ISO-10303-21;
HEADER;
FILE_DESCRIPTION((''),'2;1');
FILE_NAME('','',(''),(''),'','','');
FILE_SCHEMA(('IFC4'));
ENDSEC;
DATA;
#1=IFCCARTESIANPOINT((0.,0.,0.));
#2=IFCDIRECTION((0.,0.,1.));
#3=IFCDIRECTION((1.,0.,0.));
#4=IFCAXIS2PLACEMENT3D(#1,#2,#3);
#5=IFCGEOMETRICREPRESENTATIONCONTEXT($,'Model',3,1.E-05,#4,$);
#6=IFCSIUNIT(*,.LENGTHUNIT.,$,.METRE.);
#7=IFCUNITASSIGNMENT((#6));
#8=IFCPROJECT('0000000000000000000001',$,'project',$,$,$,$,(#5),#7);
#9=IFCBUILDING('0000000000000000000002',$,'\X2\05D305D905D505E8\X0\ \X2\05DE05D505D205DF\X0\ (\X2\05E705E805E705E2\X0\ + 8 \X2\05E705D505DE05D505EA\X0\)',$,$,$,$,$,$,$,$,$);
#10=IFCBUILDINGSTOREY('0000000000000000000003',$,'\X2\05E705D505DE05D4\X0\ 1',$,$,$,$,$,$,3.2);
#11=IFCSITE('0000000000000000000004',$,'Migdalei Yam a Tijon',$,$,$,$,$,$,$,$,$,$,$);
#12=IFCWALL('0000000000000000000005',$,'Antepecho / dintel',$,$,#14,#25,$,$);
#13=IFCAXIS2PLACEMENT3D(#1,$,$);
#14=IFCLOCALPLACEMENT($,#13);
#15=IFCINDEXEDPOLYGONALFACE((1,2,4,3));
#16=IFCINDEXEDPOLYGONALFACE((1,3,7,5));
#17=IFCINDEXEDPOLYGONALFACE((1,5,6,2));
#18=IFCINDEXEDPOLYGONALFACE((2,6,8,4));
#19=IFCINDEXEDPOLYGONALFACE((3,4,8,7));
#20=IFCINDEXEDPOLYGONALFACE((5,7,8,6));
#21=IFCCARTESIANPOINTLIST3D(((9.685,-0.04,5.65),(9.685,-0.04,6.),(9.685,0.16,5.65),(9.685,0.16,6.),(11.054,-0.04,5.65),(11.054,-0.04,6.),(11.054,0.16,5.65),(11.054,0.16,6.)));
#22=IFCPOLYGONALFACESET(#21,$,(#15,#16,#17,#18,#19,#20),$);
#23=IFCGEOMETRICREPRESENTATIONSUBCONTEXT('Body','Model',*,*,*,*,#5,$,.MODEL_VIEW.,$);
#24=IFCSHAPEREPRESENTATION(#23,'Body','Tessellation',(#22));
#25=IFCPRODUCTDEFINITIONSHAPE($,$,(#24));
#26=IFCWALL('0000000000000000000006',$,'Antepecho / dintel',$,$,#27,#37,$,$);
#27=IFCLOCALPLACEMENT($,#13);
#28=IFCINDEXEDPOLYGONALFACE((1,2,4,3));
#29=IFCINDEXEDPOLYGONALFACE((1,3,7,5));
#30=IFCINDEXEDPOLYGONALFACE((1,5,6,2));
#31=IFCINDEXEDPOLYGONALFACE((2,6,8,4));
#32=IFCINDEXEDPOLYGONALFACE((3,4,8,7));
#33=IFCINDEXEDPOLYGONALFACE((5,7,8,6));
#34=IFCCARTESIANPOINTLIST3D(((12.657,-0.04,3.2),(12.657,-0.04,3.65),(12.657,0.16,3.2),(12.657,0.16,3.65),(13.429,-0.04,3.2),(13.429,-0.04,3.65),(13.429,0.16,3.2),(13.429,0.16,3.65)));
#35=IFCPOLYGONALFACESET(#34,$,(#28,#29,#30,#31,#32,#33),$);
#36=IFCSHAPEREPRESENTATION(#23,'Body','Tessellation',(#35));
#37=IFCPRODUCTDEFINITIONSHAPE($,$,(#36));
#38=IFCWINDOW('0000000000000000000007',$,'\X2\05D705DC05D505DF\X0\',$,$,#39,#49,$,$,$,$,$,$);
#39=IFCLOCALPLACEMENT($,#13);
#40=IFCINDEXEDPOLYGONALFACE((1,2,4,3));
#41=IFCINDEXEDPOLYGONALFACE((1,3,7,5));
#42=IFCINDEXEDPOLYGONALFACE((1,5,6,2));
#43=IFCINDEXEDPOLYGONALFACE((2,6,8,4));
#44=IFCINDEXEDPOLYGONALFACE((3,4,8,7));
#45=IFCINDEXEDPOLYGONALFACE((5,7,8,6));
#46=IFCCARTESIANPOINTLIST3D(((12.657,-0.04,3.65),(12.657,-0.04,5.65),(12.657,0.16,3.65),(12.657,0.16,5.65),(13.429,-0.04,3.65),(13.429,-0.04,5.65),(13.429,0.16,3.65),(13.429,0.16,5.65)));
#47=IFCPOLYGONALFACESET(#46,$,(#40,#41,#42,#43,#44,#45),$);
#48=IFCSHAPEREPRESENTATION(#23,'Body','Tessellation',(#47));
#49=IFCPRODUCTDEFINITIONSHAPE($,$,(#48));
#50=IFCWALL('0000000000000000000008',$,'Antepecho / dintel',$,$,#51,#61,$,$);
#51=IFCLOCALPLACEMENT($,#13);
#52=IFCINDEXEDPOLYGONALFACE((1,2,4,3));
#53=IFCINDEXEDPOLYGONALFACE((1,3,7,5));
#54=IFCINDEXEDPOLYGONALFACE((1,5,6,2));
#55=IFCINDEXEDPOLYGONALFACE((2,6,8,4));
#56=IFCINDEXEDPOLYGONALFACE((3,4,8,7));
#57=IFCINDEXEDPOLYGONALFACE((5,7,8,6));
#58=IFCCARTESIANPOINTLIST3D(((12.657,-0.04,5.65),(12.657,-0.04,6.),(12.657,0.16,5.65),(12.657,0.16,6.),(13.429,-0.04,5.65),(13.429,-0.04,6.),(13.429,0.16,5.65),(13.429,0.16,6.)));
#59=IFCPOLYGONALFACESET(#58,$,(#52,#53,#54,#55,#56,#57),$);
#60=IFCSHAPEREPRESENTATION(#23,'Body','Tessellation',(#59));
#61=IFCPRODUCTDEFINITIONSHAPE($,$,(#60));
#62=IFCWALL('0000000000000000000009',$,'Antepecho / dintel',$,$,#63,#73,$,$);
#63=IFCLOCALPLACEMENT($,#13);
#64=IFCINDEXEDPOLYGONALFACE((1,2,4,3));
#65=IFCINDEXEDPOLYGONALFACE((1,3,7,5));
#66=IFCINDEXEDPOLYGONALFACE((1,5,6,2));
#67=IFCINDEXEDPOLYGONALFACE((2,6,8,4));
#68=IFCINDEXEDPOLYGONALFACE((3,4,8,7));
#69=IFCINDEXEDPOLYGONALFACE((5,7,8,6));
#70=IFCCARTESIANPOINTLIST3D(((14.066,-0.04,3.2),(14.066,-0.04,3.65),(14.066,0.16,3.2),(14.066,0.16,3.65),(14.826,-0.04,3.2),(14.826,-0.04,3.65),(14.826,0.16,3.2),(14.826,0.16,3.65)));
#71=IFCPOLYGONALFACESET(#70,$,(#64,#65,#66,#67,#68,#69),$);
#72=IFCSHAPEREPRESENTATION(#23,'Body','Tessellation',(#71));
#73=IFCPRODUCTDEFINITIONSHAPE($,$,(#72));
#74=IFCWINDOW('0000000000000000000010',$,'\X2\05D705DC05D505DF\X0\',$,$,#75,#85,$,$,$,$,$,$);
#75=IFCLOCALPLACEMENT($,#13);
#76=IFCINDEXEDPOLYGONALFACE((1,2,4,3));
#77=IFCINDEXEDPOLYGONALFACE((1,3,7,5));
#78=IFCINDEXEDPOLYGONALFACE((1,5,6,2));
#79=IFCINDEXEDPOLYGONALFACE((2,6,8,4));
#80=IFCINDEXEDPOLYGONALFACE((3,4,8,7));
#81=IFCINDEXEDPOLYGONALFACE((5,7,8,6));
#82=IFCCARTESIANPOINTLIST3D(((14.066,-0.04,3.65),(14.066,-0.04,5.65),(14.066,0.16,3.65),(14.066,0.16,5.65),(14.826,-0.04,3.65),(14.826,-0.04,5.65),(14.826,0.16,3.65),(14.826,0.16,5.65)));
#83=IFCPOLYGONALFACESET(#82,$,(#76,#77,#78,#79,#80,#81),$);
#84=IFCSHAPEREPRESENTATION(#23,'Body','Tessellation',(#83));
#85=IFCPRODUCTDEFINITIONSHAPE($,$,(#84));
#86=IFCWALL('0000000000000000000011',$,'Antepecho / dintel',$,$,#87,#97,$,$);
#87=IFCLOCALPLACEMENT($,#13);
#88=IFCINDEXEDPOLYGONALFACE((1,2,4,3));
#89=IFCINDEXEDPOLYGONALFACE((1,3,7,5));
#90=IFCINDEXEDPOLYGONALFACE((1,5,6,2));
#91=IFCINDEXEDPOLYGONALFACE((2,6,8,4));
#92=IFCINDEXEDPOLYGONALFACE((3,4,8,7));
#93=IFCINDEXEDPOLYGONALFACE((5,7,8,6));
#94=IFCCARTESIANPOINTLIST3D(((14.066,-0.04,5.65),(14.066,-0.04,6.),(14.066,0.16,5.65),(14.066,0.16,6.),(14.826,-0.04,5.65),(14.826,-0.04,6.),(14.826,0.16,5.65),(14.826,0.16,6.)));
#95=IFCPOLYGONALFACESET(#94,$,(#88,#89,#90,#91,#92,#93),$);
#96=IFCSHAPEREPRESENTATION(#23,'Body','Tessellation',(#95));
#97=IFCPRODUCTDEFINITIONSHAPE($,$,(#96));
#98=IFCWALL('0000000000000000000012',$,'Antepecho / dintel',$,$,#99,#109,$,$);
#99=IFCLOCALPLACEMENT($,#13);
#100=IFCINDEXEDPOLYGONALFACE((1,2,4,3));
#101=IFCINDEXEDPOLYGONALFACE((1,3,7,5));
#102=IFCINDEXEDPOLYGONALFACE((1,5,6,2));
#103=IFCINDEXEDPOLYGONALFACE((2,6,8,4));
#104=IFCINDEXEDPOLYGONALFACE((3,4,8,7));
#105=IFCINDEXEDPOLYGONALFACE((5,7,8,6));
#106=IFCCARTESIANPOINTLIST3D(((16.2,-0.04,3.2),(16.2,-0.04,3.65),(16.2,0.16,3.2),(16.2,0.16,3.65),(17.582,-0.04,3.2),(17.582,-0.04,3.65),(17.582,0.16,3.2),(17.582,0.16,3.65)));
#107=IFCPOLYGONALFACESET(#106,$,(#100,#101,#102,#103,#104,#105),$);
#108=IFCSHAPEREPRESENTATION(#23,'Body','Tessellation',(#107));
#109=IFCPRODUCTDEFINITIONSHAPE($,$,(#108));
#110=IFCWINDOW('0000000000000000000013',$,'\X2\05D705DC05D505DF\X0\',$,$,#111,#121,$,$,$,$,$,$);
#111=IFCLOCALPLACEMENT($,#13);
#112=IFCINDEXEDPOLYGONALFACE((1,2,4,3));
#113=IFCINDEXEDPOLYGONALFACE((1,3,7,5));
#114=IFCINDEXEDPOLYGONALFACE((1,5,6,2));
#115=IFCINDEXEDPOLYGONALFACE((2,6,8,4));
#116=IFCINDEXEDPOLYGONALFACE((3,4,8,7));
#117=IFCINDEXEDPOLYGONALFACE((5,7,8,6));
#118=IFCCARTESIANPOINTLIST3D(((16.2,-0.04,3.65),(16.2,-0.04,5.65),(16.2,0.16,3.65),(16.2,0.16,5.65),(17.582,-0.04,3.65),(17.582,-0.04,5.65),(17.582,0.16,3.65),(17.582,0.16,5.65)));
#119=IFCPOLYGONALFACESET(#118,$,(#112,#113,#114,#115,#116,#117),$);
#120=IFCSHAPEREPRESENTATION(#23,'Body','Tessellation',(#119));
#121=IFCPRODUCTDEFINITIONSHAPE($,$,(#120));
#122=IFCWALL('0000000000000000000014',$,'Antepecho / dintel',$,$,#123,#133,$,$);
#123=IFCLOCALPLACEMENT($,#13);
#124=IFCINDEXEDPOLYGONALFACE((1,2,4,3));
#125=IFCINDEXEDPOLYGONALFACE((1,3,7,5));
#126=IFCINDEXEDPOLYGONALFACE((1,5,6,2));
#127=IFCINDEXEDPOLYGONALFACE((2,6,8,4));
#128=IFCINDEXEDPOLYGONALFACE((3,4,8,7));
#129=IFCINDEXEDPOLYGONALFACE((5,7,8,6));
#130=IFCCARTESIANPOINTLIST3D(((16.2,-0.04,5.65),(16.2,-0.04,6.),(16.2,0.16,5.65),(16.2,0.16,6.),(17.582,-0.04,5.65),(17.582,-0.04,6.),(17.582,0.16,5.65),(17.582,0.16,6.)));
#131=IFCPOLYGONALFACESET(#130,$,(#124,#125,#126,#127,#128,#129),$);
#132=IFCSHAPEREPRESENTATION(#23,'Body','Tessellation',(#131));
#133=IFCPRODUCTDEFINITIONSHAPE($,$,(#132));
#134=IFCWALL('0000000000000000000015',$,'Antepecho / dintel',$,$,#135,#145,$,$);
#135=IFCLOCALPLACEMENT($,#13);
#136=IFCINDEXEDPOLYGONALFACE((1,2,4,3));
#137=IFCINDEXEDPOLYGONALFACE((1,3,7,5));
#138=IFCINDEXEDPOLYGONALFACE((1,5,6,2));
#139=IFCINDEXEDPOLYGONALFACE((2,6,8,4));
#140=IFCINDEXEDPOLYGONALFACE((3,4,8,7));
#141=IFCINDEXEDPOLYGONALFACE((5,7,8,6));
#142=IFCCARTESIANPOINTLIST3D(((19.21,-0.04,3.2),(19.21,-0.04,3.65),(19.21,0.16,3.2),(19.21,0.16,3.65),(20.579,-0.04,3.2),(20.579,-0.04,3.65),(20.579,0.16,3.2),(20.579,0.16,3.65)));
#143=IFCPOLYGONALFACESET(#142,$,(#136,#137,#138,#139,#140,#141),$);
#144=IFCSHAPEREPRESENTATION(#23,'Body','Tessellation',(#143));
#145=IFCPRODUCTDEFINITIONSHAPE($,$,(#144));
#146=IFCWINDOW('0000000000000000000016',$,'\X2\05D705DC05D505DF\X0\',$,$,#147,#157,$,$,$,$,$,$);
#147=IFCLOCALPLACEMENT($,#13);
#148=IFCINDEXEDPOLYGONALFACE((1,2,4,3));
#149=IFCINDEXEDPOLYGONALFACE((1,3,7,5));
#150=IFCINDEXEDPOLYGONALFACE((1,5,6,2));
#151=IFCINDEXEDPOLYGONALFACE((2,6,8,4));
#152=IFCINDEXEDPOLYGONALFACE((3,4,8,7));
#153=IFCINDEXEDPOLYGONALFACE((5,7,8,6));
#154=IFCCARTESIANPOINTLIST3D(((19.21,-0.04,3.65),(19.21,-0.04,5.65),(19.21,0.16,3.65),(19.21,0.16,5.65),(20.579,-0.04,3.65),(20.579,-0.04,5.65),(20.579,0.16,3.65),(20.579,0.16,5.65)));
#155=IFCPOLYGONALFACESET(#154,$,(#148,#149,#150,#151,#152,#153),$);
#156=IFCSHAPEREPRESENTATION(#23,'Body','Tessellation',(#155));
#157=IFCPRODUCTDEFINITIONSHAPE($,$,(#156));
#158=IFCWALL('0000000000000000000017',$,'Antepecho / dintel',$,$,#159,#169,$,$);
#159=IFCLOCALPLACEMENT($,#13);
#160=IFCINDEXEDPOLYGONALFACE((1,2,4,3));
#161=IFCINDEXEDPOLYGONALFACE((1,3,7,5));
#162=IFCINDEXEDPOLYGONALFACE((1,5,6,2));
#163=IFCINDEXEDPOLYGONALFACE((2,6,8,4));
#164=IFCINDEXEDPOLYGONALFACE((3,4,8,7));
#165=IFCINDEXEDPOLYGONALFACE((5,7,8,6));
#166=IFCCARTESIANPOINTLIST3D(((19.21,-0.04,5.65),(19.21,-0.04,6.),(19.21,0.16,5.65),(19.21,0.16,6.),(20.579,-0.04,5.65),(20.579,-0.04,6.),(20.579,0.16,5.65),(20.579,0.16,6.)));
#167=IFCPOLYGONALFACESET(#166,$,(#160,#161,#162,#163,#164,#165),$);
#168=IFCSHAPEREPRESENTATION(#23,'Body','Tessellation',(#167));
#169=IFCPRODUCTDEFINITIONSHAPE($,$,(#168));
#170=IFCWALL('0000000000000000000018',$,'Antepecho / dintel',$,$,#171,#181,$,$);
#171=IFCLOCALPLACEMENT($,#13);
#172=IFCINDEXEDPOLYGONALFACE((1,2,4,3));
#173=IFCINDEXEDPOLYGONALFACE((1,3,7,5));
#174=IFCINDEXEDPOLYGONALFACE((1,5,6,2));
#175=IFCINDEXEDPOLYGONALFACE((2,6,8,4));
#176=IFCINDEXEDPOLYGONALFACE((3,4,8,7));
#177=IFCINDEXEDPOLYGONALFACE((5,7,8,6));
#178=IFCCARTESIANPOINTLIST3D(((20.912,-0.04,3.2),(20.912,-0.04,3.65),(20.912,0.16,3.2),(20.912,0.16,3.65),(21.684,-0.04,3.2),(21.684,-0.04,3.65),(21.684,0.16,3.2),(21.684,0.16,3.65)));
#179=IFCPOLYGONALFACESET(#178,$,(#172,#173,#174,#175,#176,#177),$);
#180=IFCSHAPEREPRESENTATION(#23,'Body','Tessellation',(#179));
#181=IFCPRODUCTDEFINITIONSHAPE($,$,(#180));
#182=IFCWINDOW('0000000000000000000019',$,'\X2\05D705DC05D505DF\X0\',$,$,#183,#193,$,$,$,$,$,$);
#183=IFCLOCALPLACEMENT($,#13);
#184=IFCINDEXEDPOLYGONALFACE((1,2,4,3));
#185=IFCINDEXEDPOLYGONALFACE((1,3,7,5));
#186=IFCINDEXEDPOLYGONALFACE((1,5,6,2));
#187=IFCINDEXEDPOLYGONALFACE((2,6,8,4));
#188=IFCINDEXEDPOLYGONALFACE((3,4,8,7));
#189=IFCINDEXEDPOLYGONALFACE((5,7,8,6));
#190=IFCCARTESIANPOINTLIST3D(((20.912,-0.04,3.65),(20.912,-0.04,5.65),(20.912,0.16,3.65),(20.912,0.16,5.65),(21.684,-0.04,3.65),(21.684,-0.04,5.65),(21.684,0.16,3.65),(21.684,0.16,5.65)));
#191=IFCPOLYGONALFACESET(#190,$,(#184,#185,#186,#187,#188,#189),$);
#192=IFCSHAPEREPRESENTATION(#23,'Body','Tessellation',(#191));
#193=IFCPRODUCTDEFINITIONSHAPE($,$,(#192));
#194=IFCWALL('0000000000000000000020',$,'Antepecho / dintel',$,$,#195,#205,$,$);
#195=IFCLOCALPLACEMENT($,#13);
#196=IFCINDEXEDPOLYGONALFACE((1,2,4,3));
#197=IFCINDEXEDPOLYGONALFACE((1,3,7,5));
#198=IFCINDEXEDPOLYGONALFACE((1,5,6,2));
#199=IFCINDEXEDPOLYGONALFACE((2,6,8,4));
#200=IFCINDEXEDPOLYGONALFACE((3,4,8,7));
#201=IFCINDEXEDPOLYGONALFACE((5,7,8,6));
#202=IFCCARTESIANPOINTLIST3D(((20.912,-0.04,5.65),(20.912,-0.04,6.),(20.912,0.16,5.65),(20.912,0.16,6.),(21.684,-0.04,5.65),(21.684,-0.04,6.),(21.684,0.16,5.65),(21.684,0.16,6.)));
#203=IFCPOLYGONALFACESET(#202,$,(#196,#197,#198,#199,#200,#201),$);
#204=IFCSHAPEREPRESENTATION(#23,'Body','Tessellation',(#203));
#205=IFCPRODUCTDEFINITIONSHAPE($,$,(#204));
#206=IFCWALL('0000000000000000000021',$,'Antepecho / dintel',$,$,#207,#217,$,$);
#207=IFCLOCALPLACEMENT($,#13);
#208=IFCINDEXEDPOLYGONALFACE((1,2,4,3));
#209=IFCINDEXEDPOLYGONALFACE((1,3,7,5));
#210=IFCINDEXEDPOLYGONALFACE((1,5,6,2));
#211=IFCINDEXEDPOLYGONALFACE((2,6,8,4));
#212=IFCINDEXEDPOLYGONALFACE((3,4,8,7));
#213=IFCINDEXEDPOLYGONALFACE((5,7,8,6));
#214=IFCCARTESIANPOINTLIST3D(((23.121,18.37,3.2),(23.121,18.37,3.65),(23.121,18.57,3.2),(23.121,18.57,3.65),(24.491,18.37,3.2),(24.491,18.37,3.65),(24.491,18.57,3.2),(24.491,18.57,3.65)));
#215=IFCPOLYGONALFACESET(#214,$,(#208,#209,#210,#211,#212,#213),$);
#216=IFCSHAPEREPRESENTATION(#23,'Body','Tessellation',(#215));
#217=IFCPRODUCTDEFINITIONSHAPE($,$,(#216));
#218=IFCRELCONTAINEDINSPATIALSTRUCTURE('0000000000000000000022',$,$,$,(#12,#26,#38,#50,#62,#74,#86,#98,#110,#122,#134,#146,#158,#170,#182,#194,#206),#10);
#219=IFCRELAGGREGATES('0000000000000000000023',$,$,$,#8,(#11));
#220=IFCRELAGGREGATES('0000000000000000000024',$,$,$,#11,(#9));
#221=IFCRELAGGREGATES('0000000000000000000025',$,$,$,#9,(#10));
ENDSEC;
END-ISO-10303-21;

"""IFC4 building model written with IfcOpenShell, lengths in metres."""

from ifc_helpers import new_model, si_unit, frame, origin_with_axes, context, subcontext, project, spatial, line, indexed_curve, outline, extrude, element, save


model = new_model("IFC4")

# Units and contexts
model_context = context("Model", 3, precision=1e-05, world=origin_with_axes())
body_context = subcontext(model_context, "Body", "Model", "MODEL_VIEW")
ifc_project = project(units=[si_unit("LENGTHUNIT", "METRE")], contexts=[model_context])

# Site, building, storey
site = spatial("IfcSite", under=ifc_project, Name="Migdalei Yam a Tijon")
building = spatial("IfcBuilding", under=site, Name="דיור מוגן (קרקע + 8 קומות)")
storey = spatial("IfcBuildingStorey", under=building, Name="קומה 1", Elevation=3.2)

# Walls
element("IfcWall", 1, inside=storey, Name="Antepecho / dintel", context=body_context, shape_type="SweptSolid", body=[
    extrude(outline(indexed_curve([(0.0, 0.0), (1.369, 0.0), (1.369, 0.2), (0.0, 0.2)], segments=[line(1, 2, 3, 4, 1)])), frame((9.685, -0.04, 5.65), z_axis=(0.0, 0.0, 1.0), x_axis=(1.0, 0.0, 0.0)), (0.0, 0.0, 1.0), 0.35),
])
element("IfcWall", 2, inside=storey, Name="Antepecho / dintel", context=body_context, shape_type="SweptSolid", body=[
    extrude(outline(indexed_curve([(0.0, 0.0), (0.772, 0.0), (0.772, 0.2), (0.0, 0.2)], segments=[line(1, 2, 3, 4, 1)])), frame((12.657, -0.04, 3.2), z_axis=(0.0, 0.0, 1.0), x_axis=(1.0, 0.0, 0.0)), (0.0, 0.0, 1.0), 0.45),
])

# Window
element("IfcWindow", 3, inside=storey, Name="חלון", context=body_context, shape_type="SweptSolid", body=[
    extrude(outline(indexed_curve([(0.0, 0.0), (0.772, 0.0), (0.772, 0.2), (0.0, 0.2)], segments=[line(1, 2, 3, 4, 1)])), frame((12.657, -0.04, 3.65), z_axis=(0.0, 0.0, 1.0), x_axis=(1.0, 0.0, 0.0)), (0.0, 0.0, 1.0), 2.0),
])

# Walls
element("IfcWall", 4, inside=storey, Name="Antepecho / dintel", context=body_context, shape_type="SweptSolid", body=[
    extrude(outline(indexed_curve([(0.0, 0.0), (0.772, 0.0), (0.772, 0.2), (0.0, 0.2)], segments=[line(1, 2, 3, 4, 1)])), frame((12.657, -0.04, 5.65), z_axis=(0.0, 0.0, 1.0), x_axis=(1.0, 0.0, 0.0)), (0.0, 0.0, 1.0), 0.35),
])
element("IfcWall", 5, inside=storey, Name="Antepecho / dintel", context=body_context, shape_type="SweptSolid", body=[
    extrude(outline(indexed_curve([(0.0, 0.0), (0.76, 0.0), (0.76, 0.2), (0.0, 0.2)], segments=[line(1, 2, 3, 4, 1)])), frame((14.066, -0.04, 3.2), z_axis=(0.0, 0.0, 1.0), x_axis=(1.0, 0.0, 0.0)), (0.0, 0.0, 1.0), 0.45),
])

# Window
element("IfcWindow", 6, inside=storey, Name="חלון", context=body_context, shape_type="SweptSolid", body=[
    extrude(outline(indexed_curve([(0.0, 0.0), (0.76, 0.0), (0.76, 0.2), (0.0, 0.2)], segments=[line(1, 2, 3, 4, 1)])), frame((14.066, -0.04, 3.65), z_axis=(0.0, 0.0, 1.0), x_axis=(1.0, 0.0, 0.0)), (0.0, 0.0, 1.0), 2.0),
])

# Walls
element("IfcWall", 7, inside=storey, Name="Antepecho / dintel", context=body_context, shape_type="SweptSolid", body=[
    extrude(outline(indexed_curve([(0.0, 0.0), (0.76, 0.0), (0.76, 0.2), (0.0, 0.2)], segments=[line(1, 2, 3, 4, 1)])), frame((14.066, -0.04, 5.65), z_axis=(0.0, 0.0, 1.0), x_axis=(1.0, 0.0, 0.0)), (0.0, 0.0, 1.0), 0.35),
])
element("IfcWall", 8, inside=storey, Name="Antepecho / dintel", context=body_context, shape_type="SweptSolid", body=[
    extrude(outline(indexed_curve([(0.0, 0.0), (1.382, 0.0), (1.382, 0.2), (0.0, 0.2)], segments=[line(1, 2, 3, 4, 1)])), frame((16.2, -0.04, 3.2), z_axis=(0.0, 0.0, 1.0), x_axis=(1.0, 0.0, 0.0)), (0.0, 0.0, 1.0), 0.45),
])

# Window
element("IfcWindow", 9, inside=storey, Name="חלון", context=body_context, shape_type="SweptSolid", body=[
    extrude(outline(indexed_curve([(0.0, 0.0), (1.382, 0.0), (1.382, 0.2), (0.0, 0.2)], segments=[line(1, 2, 3, 4, 1)])), frame((16.2, -0.04, 3.65), z_axis=(0.0, 0.0, 1.0), x_axis=(1.0, 0.0, 0.0)), (0.0, 0.0, 1.0), 2.0),
])

# Walls
element("IfcWall", 10, inside=storey, Name="Antepecho / dintel", context=body_context, shape_type="SweptSolid", body=[
    extrude(outline(indexed_curve([(0.0, 0.0), (1.382, 0.0), (1.382, 0.2), (0.0, 0.2)], segments=[line(1, 2, 3, 4, 1)])), frame((16.2, -0.04, 5.65), z_axis=(0.0, 0.0, 1.0), x_axis=(1.0, 0.0, 0.0)), (0.0, 0.0, 1.0), 0.35),
])
element("IfcWall", 11, inside=storey, Name="Antepecho / dintel", context=body_context, shape_type="SweptSolid", body=[
    extrude(outline(indexed_curve([(0.0, 0.0), (1.369, 0.0), (1.369, 0.2), (0.0, 0.2)], segments=[line(1, 2, 3, 4, 1)])), frame((19.21, -0.04, 3.2), z_axis=(0.0, 0.0, 1.0), x_axis=(1.0, 0.0, 0.0)), (0.0, 0.0, 1.0), 0.45),
])

# Window
element("IfcWindow", 12, inside=storey, Name="חלון", context=body_context, shape_type="SweptSolid", body=[
    extrude(outline(indexed_curve([(0.0, 0.0), (1.369, 0.0), (1.369, 0.2), (0.0, 0.2)], segments=[line(1, 2, 3, 4, 1)])), frame((19.21, -0.04, 3.65), z_axis=(0.0, 0.0, 1.0), x_axis=(1.0, 0.0, 0.0)), (0.0, 0.0, 1.0), 2.0),
])

# Walls
element("IfcWall", 13, inside=storey, Name="Antepecho / dintel", context=body_context, shape_type="SweptSolid", body=[
    extrude(outline(indexed_curve([(0.0, 0.0), (1.369, 0.0), (1.369, 0.2), (0.0, 0.2)], segments=[line(1, 2, 3, 4, 1)])), frame((19.21, -0.04, 5.65), z_axis=(0.0, 0.0, 1.0), x_axis=(1.0, 0.0, 0.0)), (0.0, 0.0, 1.0), 0.35),
])
element("IfcWall", 14, inside=storey, Name="Antepecho / dintel", context=body_context, shape_type="SweptSolid", body=[
    extrude(outline(indexed_curve([(0.0, 0.0), (0.772, 0.0), (0.772, 0.2), (0.0, 0.2)], segments=[line(1, 2, 3, 4, 1)])), frame((20.912, -0.04, 3.2), z_axis=(0.0, 0.0, 1.0), x_axis=(1.0, 0.0, 0.0)), (0.0, 0.0, 1.0), 0.45),
])

# Window
element("IfcWindow", 15, inside=storey, Name="חלון", context=body_context, shape_type="SweptSolid", body=[
    extrude(outline(indexed_curve([(0.0, 0.0), (0.772, 0.0), (0.772, 0.2), (0.0, 0.2)], segments=[line(1, 2, 3, 4, 1)])), frame((20.912, -0.04, 3.65), z_axis=(0.0, 0.0, 1.0), x_axis=(1.0, 0.0, 0.0)), (0.0, 0.0, 1.0), 2.0),
])

# Walls
element("IfcWall", 16, inside=storey, Name="Antepecho / dintel", context=body_context, shape_type="SweptSolid", body=[
    extrude(outline(indexed_curve([(0.0, 0.0), (0.772, 0.0), (0.772, 0.2), (0.0, 0.2)], segments=[line(1, 2, 3, 4, 1)])), frame((20.912, -0.04, 5.65), z_axis=(0.0, 0.0, 1.0), x_axis=(1.0, 0.0, 0.0)), (0.0, 0.0, 1.0), 0.35),
])
element("IfcWall", 17, inside=storey, Name="Antepecho / dintel", context=body_context, shape_type="SweptSolid", body=[
    extrude(outline(indexed_curve([(0.0, 0.0), (1.37, 0.0), (1.37, 0.2), (0.0, 0.2)], segments=[line(1, 2, 3, 4, 1)])), frame((23.121, 18.37, 3.2), z_axis=(0.0, 0.0, 1.0), x_axis=(1.0, 0.0, 0.0)), (0.0, 0.0, 1.0), 0.45),
])

save(model, "model.ifc")
